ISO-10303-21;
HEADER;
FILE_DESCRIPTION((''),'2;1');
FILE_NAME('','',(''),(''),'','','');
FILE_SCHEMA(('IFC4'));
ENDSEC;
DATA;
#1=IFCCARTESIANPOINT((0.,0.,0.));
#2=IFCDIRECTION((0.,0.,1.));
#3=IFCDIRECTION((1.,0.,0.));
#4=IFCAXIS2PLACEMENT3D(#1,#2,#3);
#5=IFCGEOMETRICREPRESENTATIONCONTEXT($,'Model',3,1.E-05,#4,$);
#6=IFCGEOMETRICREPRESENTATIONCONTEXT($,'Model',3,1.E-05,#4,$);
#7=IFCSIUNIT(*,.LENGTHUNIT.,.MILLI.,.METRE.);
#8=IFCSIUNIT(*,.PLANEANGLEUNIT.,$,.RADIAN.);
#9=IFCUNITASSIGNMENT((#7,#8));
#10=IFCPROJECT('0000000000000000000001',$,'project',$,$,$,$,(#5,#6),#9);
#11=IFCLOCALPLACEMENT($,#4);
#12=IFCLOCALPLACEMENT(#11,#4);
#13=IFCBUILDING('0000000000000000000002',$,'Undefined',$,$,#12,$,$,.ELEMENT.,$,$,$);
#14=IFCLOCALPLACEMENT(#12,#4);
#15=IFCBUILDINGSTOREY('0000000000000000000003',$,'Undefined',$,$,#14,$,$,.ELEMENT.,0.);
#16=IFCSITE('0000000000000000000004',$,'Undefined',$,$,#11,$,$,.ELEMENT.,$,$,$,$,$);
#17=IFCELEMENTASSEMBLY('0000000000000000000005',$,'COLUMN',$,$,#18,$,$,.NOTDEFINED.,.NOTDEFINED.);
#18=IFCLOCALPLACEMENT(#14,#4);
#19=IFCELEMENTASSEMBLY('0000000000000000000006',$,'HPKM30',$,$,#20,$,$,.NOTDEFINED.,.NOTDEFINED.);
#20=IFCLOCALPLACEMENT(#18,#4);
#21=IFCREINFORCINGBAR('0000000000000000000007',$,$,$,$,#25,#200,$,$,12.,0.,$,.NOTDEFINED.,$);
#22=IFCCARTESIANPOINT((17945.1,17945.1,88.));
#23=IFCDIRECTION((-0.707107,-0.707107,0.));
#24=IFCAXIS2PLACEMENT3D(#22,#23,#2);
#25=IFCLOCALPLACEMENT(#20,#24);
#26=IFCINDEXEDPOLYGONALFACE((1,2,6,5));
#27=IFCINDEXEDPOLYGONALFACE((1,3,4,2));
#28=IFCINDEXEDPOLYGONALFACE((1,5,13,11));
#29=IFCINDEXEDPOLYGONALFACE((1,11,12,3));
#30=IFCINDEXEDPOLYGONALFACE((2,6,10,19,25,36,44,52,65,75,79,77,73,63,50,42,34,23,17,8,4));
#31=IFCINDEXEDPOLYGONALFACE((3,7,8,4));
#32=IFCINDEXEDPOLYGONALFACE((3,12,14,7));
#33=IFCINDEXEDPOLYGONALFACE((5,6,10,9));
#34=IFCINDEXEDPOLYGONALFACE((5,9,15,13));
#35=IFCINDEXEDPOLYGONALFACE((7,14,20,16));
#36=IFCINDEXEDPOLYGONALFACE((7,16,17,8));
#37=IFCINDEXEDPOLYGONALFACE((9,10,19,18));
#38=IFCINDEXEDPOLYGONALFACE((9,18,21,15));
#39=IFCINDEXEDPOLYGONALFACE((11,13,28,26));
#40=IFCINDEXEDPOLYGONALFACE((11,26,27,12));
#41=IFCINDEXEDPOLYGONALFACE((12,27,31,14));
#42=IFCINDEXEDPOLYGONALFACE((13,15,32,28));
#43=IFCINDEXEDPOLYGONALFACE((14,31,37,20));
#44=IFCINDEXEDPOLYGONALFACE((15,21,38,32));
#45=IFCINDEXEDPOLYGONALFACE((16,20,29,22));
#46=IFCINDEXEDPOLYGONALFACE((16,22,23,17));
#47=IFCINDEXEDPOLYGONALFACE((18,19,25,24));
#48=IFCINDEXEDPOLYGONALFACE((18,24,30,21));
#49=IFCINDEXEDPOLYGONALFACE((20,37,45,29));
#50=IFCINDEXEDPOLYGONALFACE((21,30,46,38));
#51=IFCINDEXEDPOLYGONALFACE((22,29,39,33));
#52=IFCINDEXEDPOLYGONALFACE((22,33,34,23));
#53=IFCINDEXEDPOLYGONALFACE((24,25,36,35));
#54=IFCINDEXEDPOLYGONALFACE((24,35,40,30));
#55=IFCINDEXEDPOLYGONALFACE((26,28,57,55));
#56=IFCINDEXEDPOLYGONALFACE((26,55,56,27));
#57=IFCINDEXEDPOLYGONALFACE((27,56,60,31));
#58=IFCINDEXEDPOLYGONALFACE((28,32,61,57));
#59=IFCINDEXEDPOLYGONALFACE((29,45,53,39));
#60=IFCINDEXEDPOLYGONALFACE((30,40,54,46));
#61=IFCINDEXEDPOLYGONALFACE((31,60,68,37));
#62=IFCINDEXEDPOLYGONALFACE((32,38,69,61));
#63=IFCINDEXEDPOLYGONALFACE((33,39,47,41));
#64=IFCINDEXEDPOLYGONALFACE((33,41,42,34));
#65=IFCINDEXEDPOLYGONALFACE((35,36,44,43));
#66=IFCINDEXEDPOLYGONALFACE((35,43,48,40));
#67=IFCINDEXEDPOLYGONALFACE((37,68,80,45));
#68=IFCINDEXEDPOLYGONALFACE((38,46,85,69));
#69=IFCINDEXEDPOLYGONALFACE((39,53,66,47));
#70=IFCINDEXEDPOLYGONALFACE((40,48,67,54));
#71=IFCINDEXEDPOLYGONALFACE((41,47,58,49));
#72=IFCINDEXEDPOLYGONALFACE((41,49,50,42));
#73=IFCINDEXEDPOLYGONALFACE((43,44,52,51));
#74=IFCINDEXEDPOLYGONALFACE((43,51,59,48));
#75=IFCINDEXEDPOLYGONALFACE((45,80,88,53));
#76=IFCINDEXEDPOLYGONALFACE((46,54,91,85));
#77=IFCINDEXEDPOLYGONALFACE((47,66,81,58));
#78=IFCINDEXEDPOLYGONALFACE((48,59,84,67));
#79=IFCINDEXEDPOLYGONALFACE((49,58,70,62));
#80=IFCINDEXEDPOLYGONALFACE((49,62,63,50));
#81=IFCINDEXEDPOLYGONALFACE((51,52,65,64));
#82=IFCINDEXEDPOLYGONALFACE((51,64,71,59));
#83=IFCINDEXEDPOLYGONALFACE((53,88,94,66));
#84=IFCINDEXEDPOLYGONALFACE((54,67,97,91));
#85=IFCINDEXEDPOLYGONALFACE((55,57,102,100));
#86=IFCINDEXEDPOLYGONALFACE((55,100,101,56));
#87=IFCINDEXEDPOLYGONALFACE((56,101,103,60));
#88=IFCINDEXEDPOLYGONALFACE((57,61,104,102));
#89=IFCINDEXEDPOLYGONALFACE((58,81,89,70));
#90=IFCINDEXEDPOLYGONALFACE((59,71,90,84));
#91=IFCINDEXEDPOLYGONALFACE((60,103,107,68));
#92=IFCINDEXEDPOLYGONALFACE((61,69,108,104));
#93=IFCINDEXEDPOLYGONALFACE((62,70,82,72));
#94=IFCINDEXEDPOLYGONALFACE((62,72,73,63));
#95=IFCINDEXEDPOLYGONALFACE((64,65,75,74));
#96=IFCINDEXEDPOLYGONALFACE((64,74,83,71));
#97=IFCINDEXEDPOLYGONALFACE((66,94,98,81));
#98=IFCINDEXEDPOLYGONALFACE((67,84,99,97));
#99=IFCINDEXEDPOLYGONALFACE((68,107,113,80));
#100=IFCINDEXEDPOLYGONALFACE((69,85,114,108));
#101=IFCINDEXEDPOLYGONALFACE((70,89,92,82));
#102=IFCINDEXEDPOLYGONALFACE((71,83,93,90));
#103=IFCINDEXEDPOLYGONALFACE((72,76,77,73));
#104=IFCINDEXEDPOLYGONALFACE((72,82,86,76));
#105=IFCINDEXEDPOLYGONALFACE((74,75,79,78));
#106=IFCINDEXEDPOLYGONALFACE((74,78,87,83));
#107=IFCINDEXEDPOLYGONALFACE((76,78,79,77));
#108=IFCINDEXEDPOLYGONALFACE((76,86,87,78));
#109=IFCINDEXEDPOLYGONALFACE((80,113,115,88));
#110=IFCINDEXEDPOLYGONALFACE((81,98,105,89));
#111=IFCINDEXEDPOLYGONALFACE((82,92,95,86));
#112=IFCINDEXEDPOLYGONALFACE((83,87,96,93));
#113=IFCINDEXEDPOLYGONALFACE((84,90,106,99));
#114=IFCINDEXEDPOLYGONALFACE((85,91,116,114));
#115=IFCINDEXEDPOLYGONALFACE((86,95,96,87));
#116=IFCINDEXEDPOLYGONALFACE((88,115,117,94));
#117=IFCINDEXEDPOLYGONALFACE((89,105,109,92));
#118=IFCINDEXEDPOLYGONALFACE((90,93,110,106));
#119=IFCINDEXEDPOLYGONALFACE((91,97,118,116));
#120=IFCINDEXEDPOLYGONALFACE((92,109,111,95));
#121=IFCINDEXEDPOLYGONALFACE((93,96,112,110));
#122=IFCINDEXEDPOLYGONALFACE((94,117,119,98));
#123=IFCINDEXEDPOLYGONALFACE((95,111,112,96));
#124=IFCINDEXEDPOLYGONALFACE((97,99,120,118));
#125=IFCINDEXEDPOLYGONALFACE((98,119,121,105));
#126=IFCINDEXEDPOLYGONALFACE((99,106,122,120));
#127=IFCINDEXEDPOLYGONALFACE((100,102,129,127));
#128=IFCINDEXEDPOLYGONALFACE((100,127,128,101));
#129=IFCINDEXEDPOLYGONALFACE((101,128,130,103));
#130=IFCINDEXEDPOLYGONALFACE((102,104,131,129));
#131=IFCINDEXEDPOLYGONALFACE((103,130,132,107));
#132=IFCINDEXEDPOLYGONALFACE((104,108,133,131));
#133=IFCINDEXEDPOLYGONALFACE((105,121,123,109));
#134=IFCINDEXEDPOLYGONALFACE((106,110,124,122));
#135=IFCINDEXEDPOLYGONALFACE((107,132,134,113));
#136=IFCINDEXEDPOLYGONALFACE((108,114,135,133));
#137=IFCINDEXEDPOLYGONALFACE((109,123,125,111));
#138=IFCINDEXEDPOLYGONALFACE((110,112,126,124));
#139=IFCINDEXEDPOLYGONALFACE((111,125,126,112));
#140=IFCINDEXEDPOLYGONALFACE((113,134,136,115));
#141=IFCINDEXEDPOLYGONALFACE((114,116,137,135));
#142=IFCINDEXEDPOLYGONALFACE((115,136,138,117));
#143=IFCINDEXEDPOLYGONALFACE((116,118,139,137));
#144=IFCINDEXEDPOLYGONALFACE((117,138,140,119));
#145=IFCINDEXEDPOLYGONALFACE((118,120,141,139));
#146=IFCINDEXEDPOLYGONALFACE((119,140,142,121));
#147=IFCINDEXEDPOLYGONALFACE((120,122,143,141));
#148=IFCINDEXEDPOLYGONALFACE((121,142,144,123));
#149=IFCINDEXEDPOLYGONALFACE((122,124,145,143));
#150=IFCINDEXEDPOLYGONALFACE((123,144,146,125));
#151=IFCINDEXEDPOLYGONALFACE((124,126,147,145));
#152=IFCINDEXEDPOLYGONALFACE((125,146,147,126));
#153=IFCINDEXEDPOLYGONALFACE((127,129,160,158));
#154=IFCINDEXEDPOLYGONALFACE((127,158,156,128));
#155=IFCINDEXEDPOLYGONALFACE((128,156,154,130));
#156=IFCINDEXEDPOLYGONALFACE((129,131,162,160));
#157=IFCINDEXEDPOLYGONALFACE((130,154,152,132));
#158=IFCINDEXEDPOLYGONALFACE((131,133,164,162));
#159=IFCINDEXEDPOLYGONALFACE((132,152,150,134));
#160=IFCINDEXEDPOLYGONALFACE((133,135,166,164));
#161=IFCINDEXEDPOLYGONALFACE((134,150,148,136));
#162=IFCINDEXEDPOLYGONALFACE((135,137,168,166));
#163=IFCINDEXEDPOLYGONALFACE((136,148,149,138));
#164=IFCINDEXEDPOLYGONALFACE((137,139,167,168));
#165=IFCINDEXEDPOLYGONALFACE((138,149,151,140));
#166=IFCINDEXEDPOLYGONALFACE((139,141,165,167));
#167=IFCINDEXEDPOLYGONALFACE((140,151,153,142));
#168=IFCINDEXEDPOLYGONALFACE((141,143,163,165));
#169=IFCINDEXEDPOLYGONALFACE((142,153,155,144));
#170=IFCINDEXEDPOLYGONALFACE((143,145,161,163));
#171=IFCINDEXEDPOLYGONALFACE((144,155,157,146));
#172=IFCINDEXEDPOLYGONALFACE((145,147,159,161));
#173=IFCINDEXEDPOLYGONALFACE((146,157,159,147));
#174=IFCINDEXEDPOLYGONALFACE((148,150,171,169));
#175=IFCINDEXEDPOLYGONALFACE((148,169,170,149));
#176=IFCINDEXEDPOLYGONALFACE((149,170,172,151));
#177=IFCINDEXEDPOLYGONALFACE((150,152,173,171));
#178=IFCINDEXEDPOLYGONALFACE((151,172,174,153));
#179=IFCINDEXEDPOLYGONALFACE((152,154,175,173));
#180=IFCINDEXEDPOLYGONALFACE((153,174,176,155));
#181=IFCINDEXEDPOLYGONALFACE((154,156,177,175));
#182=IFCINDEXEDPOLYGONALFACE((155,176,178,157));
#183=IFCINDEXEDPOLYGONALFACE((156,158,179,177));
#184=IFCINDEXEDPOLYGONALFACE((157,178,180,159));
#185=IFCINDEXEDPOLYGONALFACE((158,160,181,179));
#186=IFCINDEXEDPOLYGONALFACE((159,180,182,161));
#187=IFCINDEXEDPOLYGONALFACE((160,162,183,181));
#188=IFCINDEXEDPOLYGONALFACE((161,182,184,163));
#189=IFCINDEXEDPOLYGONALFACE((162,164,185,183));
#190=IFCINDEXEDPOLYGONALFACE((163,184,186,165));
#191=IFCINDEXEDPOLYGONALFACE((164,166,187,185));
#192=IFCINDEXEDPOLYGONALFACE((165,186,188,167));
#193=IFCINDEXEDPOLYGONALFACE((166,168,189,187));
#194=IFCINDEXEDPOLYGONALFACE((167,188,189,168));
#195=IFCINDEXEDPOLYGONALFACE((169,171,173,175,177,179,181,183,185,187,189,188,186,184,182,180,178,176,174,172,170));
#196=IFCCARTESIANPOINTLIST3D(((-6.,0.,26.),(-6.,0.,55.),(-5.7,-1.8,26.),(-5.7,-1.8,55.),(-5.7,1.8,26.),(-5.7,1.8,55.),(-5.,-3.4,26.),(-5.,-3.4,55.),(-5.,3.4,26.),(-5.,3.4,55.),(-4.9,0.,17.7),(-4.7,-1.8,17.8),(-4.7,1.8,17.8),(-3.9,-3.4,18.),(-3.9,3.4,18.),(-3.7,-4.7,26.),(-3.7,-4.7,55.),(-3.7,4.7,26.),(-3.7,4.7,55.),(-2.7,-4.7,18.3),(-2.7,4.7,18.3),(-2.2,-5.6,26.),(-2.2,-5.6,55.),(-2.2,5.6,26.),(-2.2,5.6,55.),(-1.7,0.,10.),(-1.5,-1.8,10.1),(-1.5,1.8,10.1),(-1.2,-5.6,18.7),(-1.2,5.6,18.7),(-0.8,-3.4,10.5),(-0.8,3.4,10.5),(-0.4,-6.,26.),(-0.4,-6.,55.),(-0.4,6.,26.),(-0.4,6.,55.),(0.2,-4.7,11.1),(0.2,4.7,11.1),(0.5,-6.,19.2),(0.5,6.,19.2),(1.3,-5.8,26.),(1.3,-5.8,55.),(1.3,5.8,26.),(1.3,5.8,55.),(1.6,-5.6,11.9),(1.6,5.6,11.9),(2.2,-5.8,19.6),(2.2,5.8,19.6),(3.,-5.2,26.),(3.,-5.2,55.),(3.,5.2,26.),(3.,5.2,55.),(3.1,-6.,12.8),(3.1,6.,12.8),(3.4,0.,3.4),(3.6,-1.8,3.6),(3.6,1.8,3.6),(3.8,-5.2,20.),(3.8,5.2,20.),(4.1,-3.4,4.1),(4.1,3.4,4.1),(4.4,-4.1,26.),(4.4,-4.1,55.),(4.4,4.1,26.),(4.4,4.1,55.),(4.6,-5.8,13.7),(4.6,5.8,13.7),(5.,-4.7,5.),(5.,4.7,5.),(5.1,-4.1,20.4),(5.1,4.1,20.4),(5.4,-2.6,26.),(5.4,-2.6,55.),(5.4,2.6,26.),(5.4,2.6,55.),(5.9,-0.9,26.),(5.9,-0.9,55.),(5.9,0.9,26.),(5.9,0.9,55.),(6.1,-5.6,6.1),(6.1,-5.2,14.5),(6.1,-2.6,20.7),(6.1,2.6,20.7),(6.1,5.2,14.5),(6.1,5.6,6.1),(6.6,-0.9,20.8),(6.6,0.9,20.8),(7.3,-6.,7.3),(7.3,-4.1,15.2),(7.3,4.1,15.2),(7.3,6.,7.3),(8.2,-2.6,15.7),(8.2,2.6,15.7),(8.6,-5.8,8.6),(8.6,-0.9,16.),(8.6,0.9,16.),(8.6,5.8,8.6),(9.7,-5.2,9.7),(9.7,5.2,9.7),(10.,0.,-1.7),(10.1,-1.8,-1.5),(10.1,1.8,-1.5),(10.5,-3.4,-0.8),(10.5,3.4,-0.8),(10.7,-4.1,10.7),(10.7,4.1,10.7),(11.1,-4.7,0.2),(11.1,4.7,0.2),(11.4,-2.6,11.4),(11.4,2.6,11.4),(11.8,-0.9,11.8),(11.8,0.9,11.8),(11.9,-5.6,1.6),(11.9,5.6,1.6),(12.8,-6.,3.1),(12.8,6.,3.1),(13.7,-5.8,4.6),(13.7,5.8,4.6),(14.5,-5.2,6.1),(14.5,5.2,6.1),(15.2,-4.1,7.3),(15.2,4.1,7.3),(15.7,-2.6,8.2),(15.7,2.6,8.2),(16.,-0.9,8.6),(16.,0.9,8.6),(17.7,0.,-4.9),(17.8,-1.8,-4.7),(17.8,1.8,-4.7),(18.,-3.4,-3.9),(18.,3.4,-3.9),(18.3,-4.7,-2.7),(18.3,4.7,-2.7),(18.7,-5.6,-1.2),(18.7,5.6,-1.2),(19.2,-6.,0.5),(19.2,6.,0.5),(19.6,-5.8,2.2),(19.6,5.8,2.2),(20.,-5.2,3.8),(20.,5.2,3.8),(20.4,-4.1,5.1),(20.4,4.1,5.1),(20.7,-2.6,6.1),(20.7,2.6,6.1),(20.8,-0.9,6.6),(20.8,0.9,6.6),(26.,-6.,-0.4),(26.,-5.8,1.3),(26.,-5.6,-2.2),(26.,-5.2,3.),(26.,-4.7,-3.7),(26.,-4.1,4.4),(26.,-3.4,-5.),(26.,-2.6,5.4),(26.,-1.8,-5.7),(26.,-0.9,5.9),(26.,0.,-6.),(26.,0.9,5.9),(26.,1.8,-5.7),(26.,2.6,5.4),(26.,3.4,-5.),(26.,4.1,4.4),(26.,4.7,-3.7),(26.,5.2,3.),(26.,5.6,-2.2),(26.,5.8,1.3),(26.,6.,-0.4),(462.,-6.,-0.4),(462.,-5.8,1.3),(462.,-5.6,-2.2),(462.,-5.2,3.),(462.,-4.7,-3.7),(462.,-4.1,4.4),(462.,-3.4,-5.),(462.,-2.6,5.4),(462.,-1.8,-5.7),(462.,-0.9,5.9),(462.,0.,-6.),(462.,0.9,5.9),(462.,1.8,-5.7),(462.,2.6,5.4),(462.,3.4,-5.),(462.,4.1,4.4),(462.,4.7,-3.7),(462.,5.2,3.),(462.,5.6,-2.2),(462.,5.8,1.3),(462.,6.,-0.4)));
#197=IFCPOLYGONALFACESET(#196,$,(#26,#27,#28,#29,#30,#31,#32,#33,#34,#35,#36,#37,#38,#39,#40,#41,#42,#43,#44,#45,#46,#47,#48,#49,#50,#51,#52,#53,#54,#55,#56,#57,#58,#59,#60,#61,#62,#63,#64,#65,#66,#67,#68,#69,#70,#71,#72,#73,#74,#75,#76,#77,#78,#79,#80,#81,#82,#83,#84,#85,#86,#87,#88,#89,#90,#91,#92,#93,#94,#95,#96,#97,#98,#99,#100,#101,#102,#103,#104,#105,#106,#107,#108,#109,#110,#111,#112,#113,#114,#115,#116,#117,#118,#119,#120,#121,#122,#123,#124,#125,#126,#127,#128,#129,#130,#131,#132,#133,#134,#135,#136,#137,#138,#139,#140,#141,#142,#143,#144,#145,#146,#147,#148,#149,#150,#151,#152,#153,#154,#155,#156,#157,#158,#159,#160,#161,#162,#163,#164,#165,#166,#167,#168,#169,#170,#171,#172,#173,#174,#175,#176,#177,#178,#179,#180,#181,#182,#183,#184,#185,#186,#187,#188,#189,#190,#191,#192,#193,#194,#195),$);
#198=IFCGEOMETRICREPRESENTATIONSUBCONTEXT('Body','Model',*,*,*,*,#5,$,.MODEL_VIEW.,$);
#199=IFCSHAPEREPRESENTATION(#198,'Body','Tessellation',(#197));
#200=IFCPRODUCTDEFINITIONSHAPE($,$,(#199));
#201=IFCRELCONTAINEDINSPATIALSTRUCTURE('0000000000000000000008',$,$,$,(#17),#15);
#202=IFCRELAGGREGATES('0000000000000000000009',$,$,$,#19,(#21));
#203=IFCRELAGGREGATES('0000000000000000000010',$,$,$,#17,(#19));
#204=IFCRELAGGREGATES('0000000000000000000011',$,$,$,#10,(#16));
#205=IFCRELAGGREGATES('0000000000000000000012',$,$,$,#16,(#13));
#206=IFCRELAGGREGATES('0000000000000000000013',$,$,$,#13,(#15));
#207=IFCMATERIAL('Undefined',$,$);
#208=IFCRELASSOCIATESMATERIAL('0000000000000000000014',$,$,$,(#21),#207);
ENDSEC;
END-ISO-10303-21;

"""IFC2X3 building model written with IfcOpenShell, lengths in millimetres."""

from ifc_helpers import new_model, entity, si_unit, frame, origin_with_axes, place, context, subcontext, project, spatial, source, transform, mapped, material, element, aggregate, save


model = new_model("IFC2X3")

# Units and contexts
model_context_1 = context("Model", 3, precision=1e-05, world=origin_with_axes())
model_context_2 = context("Model", 3, precision=1e-05, world=origin_with_axes())
body_context = subcontext(model_context_1, "Body", "Model", "MODEL_VIEW")
ifc_project = project(units=[si_unit("LENGTHUNIT", "METRE", prefix="MILLI"), si_unit("PLANEANGLEUNIT", "RADIAN")], contexts=[model_context_1, model_context_2])

# Site, building, storey
site_placement = place(None, origin_with_axes())
site = spatial("IfcSite", under=ifc_project, at=site_placement, Name="Undefined", CompositionType="ELEMENT")
building_placement = place(site_placement, origin_with_axes())
building = spatial("IfcBuilding", under=site, at=building_placement, Name="Undefined", CompositionType="ELEMENT")
storey_placement = place(building_placement, origin_with_axes())
storey = spatial("IfcBuildingStorey", under=building, at=storey_placement, Name="Undefined", CompositionType="ELEMENT", Elevation=0.0)

# Element assembly
assembly_1_placement = place(storey_placement, origin_with_axes())
assembly_1 = element("IfcElementAssembly", 1, at=assembly_1_placement, inside=storey, Name="COLUMN", AssemblyPlace="NOTDEFINED", PredefinedType="NOTDEFINED")

# Element assembly
assembly_2_placement = place(assembly_1_placement, origin_with_axes())
assembly_2 = element("IfcElementAssembly", 2, at=assembly_2_placement, Name="HPKM30", AssemblyPlace="NOTDEFINED", PredefinedType="NOTDEFINED")

# Reinforcing bar
ifc_material_1 = material(Name="Undefined")
shared_shape_1 = source(origin_with_axes(), body_context, "Body", "AdvancedSweptSolid", [
    entity("IfcSweptDiskSolid", entity("IfcCompositeCurve", [entity("IfcCompositeCurveSegment", "CONTINUOUS", True, entity("IfcTrimmedCurve", entity("IfcLine", entity("IfcCartesianPoint", [0.0, 0.0, 0.0]), entity("IfcVector", entity("IfcDirection", [0.0, 0.0, -1.0]), 1.0)), [entity("IfcParameterValue", 0.0)], [entity("IfcParameterValue", 29.0)], True, "PARAMETER")), entity("IfcCompositeCurveSegment", "CONTINUOUS", True, entity("IfcTrimmedCurve", entity("IfcCircle", entity("IfcAxis2Placement3D", entity("IfcCartesianPoint", [26.0, 0.0, -29.0]), entity("IfcDirection", [0.0, -1.0, 0.0]), entity("IfcDirection", [-1.0, 0.0, 0.0])), 26.0), [entity("IfcParameterValue", 0.0)], [entity("IfcParameterValue", 1.570796)], True, "PARAMETER")), entity("IfcCompositeCurveSegment", "DISCONTINUOUS", True, entity("IfcTrimmedCurve", entity("IfcLine", entity("IfcCartesianPoint", [26.0, 0.0, -55.0]), entity("IfcVector", entity("IfcDirection", [1.0, 0.0, 0.0]), 1.0)), [entity("IfcParameterValue", 0.0)], [entity("IfcParameterValue", 436.0)], True, "PARAMETER"))], False), 6.0, None, 0.0, 466.6),
])
reinforcing_bar_1_placement = place(assembly_2_placement, frame((17945.1, 17945.1, 88.0), z_axis=(-0.707107, -0.707107, 0.0), x_axis=(0.0, 0.0, 1.0)))
reinforcing_bar_1 = element("IfcReinforcingBar", 3, at=reinforcing_bar_1_placement, material=ifc_material_1, BarRole="NOTDEFINED", CrossSectionArea=0.0, NominalDiameter=12.0, context=body_context, shape_type="MappedRepresentation", body=[
    mapped(shared_shape_1, transform((0.0, 0.0, 55.0))),
])
aggregate(assembly_2, [reinforcing_bar_1])

aggregate(assembly_1, [assembly_2])

save(model, "model.ifc")
